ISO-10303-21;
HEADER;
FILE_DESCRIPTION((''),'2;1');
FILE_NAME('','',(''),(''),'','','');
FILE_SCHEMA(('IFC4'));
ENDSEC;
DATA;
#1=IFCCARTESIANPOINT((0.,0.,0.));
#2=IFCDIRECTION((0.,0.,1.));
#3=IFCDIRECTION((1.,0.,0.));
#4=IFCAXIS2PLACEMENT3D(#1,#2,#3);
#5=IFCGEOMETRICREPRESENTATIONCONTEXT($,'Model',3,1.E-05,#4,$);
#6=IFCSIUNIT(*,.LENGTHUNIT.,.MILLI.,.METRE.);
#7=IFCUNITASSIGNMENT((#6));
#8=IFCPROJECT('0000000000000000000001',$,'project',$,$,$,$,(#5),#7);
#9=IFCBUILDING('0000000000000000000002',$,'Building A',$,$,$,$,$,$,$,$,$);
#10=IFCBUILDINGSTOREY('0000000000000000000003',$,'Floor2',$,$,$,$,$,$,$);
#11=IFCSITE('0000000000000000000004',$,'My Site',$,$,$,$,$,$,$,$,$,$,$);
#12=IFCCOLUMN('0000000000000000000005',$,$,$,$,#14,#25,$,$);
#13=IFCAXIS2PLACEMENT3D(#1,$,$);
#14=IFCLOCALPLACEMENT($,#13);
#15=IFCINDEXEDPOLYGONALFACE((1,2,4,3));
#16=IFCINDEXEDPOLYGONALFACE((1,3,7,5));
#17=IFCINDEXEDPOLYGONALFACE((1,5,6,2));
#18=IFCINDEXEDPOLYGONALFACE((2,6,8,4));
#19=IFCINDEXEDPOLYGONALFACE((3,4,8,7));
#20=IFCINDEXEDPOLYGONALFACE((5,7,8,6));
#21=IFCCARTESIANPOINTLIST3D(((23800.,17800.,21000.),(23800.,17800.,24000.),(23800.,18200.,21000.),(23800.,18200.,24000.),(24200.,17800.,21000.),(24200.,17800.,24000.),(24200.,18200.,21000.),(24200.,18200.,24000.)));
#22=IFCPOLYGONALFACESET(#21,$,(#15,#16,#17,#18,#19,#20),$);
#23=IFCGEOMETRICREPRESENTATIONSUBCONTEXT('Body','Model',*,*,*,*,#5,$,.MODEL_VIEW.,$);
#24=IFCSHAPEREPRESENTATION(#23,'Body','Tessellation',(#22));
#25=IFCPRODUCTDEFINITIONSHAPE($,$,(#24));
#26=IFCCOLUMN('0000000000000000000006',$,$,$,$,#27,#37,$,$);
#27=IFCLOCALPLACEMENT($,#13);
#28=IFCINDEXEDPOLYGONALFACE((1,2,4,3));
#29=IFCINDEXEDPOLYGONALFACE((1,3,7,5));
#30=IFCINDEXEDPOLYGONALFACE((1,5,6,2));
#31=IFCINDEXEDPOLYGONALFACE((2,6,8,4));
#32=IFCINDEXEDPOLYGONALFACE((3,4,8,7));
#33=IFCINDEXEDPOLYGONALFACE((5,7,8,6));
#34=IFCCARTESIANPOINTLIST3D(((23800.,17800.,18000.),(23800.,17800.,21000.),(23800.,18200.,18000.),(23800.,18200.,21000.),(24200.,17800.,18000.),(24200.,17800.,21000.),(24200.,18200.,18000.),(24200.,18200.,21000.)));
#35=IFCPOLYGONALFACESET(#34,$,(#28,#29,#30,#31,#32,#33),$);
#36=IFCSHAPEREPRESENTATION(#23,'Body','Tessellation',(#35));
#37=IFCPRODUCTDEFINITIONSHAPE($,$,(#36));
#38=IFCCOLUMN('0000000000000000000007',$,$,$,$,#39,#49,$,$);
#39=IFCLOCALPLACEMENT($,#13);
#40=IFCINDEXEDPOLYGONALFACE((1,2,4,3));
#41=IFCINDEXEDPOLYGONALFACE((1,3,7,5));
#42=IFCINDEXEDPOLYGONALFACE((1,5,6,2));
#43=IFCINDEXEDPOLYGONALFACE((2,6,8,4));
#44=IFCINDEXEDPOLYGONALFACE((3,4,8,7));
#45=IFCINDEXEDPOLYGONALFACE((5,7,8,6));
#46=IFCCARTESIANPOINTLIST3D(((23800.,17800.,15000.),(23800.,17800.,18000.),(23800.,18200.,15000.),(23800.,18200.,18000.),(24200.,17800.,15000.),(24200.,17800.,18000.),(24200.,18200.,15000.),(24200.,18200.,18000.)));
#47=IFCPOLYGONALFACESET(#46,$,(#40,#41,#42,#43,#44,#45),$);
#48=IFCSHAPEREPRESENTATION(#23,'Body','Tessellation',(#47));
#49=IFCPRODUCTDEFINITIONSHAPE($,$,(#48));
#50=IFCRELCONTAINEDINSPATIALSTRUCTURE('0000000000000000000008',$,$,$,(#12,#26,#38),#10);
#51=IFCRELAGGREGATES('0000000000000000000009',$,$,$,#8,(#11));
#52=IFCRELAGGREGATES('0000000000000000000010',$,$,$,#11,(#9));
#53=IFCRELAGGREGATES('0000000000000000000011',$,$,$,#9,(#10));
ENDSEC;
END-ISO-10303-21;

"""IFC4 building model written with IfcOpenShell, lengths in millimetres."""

from ifc_helpers import new_model, si_unit, frame, origin_with_axes, place, context, subcontext, project, spatial, line, indexed_curve, outline, extrude, element, save


model = new_model("IFC4")

# Units and contexts
model_context = context("Model", 3, precision=1e-05, world=origin_with_axes())
body_context = subcontext(model_context, "Body", "Model", "MODEL_VIEW")
ifc_project = project(units=[si_unit("LENGTHUNIT", "METRE", prefix="MILLI")], contexts=[model_context])

# Site, building, storey
site = spatial("IfcSite", under=ifc_project, Name="My Site")
building = spatial("IfcBuilding", under=site, Name="Building A")
storey = spatial("IfcBuildingStorey", under=building, Name="Floor2")

# Columns
for number, where, z_axis, x_axis in (
    (1, (24000.0, 18000.0, 21000.0), (0.0, 0.0, 1.0), (1.0, 0.0, 0.0)),
    (2, (24000.0, 18000.0, 18000.0), (0.0, 0.0, 1.0), (1.0, 0.0, 0.0)),
    (3, (24000.0, 18000.0, 15000.0), (0.0, 0.0, 1.0), (1.0, 0.0, 0.0)),
):
    element("IfcColumn", number, at=place(None, frame(where, z_axis=z_axis, x_axis=x_axis)), inside=storey, context=body_context, shape_type="SweptSolid", body=[
        extrude(outline(indexed_curve([(-200.0, -200.0), (200.0, -200.0), (200.0, 200.0), (-200.0, 200.0)], segments=[line(1, 2, 3, 4, 1)])), origin_with_axes(), (0.0, 0.0, 1.0), 3000.0),
    ])

save(model, "model.ifc")
